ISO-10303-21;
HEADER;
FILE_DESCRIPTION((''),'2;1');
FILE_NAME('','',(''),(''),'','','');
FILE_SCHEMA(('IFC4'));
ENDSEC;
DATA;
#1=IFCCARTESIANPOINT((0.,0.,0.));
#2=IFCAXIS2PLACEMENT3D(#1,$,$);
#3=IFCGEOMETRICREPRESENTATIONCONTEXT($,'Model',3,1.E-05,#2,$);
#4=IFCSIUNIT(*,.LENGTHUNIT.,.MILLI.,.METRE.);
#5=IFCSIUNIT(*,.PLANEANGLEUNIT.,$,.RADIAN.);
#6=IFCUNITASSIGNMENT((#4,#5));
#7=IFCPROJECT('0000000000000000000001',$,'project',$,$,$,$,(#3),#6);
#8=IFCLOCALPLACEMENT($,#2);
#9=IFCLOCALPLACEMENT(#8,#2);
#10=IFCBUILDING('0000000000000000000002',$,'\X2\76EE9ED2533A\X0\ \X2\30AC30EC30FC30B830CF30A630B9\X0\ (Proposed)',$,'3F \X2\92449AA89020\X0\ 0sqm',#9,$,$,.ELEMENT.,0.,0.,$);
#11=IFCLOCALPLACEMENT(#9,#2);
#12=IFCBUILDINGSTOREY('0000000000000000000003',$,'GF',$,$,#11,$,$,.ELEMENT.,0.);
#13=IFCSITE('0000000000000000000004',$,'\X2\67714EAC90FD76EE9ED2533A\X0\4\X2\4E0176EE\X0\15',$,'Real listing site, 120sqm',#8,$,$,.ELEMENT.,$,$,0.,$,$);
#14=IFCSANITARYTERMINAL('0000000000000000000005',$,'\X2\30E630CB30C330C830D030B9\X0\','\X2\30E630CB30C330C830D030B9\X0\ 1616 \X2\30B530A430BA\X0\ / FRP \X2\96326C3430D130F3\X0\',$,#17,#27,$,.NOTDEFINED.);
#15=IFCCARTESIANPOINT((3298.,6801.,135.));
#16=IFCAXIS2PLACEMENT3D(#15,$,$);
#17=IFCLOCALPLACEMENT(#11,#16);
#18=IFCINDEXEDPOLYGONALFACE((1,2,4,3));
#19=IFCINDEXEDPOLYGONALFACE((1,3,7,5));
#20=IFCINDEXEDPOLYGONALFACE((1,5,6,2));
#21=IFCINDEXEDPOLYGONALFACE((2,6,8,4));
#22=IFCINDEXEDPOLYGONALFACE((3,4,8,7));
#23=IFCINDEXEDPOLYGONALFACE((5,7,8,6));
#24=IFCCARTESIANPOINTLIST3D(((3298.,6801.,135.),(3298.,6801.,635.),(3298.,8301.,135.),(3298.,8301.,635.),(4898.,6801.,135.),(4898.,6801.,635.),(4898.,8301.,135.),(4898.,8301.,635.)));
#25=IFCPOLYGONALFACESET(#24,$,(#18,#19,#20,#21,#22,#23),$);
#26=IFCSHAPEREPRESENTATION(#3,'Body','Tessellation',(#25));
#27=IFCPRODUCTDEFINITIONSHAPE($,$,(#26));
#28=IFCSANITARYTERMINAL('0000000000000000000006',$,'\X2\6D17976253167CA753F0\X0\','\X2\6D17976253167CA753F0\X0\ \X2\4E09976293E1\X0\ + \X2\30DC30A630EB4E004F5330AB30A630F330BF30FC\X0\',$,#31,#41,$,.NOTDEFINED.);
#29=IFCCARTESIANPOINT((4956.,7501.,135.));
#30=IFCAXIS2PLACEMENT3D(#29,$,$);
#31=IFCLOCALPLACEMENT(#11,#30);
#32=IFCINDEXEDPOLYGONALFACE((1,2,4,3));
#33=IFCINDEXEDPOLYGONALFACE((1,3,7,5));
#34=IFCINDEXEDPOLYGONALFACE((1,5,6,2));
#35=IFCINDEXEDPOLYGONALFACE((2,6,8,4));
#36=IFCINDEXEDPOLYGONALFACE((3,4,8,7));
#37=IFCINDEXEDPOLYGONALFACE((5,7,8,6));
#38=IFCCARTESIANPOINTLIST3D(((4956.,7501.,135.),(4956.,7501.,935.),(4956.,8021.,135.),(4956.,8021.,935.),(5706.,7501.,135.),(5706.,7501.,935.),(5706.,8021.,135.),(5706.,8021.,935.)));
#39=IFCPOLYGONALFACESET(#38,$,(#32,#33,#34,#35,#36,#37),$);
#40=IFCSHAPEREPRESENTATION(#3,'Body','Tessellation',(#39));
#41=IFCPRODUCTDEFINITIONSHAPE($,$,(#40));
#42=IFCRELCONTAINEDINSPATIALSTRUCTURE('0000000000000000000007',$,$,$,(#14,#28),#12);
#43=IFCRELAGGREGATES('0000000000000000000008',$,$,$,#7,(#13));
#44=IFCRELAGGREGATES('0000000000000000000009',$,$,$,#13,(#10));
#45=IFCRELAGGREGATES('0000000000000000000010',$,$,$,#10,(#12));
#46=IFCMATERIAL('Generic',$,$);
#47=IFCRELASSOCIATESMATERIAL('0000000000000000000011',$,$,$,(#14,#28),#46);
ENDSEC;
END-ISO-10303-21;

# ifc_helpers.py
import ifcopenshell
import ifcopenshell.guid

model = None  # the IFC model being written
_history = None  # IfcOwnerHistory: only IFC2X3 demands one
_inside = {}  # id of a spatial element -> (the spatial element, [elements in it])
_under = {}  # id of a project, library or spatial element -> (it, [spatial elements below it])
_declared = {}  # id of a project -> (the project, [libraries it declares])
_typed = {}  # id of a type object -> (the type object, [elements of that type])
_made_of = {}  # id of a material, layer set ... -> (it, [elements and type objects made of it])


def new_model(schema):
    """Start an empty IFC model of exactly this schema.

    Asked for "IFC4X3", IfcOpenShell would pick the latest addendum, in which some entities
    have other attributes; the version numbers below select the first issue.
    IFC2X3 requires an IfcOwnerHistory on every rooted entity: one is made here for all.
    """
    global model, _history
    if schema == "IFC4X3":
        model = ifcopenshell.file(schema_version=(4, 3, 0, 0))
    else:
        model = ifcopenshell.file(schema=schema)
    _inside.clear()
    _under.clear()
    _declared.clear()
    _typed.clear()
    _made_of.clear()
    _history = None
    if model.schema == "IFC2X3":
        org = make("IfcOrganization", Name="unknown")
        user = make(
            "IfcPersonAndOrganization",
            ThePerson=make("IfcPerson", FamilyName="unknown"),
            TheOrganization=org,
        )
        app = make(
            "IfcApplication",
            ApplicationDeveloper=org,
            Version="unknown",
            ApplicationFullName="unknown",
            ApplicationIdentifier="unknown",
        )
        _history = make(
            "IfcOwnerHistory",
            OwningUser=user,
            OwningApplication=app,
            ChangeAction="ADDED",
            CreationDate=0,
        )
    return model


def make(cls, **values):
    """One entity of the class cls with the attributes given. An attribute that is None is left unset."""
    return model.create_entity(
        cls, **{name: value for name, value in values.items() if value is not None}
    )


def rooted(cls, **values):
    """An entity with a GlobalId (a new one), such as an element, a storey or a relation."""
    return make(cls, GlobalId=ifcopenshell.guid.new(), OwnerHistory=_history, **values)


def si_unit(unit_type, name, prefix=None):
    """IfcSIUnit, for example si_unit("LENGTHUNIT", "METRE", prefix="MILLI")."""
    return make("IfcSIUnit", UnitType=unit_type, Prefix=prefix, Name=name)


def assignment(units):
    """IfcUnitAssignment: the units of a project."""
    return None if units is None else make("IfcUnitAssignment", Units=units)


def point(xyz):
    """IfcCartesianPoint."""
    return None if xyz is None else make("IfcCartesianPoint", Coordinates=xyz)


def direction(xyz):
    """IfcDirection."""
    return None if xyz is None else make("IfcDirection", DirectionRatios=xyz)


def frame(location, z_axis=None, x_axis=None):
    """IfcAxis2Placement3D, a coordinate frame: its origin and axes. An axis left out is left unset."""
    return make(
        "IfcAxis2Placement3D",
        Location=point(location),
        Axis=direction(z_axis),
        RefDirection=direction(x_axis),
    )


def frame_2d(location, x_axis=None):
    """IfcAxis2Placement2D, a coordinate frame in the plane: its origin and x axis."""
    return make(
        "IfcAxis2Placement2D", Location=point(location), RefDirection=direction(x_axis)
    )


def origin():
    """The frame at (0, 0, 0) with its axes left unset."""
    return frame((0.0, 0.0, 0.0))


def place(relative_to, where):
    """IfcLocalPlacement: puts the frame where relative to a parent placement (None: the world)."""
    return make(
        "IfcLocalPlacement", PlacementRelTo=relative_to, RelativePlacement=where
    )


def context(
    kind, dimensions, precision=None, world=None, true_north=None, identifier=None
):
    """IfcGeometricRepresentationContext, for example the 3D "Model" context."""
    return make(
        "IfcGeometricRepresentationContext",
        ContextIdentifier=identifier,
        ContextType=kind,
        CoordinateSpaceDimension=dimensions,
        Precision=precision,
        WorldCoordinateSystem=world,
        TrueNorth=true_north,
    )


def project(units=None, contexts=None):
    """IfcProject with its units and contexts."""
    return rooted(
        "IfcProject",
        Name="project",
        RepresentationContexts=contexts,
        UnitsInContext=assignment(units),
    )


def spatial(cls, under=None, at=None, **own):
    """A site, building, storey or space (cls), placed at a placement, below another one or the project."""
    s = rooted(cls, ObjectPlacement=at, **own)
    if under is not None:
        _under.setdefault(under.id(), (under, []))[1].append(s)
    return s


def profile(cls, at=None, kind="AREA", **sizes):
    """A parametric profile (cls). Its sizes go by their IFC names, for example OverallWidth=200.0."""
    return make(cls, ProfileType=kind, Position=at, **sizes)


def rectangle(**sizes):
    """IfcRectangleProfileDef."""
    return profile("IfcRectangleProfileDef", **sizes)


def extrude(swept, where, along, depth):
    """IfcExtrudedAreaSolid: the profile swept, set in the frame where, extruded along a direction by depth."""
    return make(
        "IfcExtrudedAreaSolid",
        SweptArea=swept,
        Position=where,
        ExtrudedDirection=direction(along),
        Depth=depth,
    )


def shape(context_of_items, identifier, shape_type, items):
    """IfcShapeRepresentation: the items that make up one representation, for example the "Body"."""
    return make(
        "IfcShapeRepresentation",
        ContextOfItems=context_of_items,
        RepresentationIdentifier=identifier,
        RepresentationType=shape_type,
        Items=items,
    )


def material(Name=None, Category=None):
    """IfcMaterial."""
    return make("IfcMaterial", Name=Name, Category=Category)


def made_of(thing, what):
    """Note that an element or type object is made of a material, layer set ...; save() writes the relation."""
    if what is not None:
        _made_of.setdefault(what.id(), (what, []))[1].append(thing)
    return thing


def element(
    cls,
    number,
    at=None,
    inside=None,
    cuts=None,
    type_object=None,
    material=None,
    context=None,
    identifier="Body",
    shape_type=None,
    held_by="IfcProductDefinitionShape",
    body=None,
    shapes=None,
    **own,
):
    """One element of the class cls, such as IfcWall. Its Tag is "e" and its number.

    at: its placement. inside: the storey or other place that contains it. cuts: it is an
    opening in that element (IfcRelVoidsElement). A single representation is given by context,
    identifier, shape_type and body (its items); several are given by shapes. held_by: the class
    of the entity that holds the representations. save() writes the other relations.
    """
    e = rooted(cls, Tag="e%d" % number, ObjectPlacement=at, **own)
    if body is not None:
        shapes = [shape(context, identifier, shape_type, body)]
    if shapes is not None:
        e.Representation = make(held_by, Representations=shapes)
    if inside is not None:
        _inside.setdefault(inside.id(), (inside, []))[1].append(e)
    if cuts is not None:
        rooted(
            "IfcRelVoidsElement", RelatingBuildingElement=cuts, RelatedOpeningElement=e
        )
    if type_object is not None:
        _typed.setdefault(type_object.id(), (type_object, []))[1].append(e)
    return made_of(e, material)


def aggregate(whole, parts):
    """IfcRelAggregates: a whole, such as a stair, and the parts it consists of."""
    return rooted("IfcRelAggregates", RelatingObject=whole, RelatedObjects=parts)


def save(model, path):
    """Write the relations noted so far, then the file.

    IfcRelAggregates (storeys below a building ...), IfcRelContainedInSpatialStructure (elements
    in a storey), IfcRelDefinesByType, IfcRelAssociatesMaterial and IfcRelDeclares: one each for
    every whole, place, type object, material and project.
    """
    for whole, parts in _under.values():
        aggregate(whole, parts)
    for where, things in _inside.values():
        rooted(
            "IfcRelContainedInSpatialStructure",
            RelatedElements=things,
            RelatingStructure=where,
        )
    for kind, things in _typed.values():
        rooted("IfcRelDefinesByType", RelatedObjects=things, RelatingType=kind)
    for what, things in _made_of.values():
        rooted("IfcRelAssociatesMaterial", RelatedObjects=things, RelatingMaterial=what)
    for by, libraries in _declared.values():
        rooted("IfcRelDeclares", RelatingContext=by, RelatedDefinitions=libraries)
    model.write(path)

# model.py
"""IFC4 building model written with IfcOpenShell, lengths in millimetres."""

from ifc_helpers import new_model, si_unit, frame, frame_2d, origin, place, context, project, spatial, rectangle, extrude, material, element, save


model = new_model("IFC4")

# Units and contexts
model_context = context("Model", 3, precision=1e-05, world=origin())
ifc_project = project(units=[si_unit("LENGTHUNIT", "METRE", prefix="MILLI"), si_unit("PLANEANGLEUNIT", "RADIAN")], contexts=[model_context])

# Site, building, storey
site_placement = place(None, origin())
site = spatial("IfcSite", under=ifc_project, at=site_placement, Name="東京都目黒区4丁目15", ObjectType="Real listing site, 120sqm", CompositionType="ELEMENT", RefElevation=0.0)
building_placement = place(site_placement, origin())
building = spatial("IfcBuilding", under=site, at=building_placement, Name="目黒区 ガレージハウス (Proposed)", ObjectType="3F 鉄骨造 0sqm", CompositionType="ELEMENT", ElevationOfRefHeight=0.0, ElevationOfTerrain=0.0)
storey_placement = place(building_placement, origin())
storey = spatial("IfcBuildingStorey", under=building, at=storey_placement, Name="GF", CompositionType="ELEMENT", Elevation=0.0)

# Shared definitions
ifc_material_1 = material(Name="Generic")

# Sanitary terminals
sanitary_terminal_1_placement = place(storey_placement, frame((3298.0, 6801.0, 135.0)))
element("IfcSanitaryTerminal", 1, at=sanitary_terminal_1_placement, inside=storey, material=ifc_material_1, Name="ユニットバス", Description="ユニットバス 1616 サイズ / FRP 防水パン", PredefinedType="NOTDEFINED", context=model_context, shape_type="SweptSolid", body=[
    extrude(rectangle(XDim=1600.0, YDim=1500.0, at=frame_2d((800.0, 750.0))), frame((3298.0, 6801.0, 135.0)), (0.0, 0.0, 1.0), 500.0),
])
sanitary_terminal_2_placement = place(storey_placement, frame((4956.0, 7501.0, 135.0)))
element("IfcSanitaryTerminal", 2, at=sanitary_terminal_2_placement, inside=storey, material=ifc_material_1, Name="洗面化粧台", Description="洗面化粧台 三面鏡 + ボウル一体カウンター", PredefinedType="NOTDEFINED", context=model_context, shape_type="SweptSolid", body=[
    extrude(rectangle(XDim=750.0, YDim=520.0, at=frame_2d((375.0, 260.0))), frame((4956.0, 7501.0, 135.0)), (0.0, 0.0, 1.0), 800.0),
])

save(model, "model.ifc")
